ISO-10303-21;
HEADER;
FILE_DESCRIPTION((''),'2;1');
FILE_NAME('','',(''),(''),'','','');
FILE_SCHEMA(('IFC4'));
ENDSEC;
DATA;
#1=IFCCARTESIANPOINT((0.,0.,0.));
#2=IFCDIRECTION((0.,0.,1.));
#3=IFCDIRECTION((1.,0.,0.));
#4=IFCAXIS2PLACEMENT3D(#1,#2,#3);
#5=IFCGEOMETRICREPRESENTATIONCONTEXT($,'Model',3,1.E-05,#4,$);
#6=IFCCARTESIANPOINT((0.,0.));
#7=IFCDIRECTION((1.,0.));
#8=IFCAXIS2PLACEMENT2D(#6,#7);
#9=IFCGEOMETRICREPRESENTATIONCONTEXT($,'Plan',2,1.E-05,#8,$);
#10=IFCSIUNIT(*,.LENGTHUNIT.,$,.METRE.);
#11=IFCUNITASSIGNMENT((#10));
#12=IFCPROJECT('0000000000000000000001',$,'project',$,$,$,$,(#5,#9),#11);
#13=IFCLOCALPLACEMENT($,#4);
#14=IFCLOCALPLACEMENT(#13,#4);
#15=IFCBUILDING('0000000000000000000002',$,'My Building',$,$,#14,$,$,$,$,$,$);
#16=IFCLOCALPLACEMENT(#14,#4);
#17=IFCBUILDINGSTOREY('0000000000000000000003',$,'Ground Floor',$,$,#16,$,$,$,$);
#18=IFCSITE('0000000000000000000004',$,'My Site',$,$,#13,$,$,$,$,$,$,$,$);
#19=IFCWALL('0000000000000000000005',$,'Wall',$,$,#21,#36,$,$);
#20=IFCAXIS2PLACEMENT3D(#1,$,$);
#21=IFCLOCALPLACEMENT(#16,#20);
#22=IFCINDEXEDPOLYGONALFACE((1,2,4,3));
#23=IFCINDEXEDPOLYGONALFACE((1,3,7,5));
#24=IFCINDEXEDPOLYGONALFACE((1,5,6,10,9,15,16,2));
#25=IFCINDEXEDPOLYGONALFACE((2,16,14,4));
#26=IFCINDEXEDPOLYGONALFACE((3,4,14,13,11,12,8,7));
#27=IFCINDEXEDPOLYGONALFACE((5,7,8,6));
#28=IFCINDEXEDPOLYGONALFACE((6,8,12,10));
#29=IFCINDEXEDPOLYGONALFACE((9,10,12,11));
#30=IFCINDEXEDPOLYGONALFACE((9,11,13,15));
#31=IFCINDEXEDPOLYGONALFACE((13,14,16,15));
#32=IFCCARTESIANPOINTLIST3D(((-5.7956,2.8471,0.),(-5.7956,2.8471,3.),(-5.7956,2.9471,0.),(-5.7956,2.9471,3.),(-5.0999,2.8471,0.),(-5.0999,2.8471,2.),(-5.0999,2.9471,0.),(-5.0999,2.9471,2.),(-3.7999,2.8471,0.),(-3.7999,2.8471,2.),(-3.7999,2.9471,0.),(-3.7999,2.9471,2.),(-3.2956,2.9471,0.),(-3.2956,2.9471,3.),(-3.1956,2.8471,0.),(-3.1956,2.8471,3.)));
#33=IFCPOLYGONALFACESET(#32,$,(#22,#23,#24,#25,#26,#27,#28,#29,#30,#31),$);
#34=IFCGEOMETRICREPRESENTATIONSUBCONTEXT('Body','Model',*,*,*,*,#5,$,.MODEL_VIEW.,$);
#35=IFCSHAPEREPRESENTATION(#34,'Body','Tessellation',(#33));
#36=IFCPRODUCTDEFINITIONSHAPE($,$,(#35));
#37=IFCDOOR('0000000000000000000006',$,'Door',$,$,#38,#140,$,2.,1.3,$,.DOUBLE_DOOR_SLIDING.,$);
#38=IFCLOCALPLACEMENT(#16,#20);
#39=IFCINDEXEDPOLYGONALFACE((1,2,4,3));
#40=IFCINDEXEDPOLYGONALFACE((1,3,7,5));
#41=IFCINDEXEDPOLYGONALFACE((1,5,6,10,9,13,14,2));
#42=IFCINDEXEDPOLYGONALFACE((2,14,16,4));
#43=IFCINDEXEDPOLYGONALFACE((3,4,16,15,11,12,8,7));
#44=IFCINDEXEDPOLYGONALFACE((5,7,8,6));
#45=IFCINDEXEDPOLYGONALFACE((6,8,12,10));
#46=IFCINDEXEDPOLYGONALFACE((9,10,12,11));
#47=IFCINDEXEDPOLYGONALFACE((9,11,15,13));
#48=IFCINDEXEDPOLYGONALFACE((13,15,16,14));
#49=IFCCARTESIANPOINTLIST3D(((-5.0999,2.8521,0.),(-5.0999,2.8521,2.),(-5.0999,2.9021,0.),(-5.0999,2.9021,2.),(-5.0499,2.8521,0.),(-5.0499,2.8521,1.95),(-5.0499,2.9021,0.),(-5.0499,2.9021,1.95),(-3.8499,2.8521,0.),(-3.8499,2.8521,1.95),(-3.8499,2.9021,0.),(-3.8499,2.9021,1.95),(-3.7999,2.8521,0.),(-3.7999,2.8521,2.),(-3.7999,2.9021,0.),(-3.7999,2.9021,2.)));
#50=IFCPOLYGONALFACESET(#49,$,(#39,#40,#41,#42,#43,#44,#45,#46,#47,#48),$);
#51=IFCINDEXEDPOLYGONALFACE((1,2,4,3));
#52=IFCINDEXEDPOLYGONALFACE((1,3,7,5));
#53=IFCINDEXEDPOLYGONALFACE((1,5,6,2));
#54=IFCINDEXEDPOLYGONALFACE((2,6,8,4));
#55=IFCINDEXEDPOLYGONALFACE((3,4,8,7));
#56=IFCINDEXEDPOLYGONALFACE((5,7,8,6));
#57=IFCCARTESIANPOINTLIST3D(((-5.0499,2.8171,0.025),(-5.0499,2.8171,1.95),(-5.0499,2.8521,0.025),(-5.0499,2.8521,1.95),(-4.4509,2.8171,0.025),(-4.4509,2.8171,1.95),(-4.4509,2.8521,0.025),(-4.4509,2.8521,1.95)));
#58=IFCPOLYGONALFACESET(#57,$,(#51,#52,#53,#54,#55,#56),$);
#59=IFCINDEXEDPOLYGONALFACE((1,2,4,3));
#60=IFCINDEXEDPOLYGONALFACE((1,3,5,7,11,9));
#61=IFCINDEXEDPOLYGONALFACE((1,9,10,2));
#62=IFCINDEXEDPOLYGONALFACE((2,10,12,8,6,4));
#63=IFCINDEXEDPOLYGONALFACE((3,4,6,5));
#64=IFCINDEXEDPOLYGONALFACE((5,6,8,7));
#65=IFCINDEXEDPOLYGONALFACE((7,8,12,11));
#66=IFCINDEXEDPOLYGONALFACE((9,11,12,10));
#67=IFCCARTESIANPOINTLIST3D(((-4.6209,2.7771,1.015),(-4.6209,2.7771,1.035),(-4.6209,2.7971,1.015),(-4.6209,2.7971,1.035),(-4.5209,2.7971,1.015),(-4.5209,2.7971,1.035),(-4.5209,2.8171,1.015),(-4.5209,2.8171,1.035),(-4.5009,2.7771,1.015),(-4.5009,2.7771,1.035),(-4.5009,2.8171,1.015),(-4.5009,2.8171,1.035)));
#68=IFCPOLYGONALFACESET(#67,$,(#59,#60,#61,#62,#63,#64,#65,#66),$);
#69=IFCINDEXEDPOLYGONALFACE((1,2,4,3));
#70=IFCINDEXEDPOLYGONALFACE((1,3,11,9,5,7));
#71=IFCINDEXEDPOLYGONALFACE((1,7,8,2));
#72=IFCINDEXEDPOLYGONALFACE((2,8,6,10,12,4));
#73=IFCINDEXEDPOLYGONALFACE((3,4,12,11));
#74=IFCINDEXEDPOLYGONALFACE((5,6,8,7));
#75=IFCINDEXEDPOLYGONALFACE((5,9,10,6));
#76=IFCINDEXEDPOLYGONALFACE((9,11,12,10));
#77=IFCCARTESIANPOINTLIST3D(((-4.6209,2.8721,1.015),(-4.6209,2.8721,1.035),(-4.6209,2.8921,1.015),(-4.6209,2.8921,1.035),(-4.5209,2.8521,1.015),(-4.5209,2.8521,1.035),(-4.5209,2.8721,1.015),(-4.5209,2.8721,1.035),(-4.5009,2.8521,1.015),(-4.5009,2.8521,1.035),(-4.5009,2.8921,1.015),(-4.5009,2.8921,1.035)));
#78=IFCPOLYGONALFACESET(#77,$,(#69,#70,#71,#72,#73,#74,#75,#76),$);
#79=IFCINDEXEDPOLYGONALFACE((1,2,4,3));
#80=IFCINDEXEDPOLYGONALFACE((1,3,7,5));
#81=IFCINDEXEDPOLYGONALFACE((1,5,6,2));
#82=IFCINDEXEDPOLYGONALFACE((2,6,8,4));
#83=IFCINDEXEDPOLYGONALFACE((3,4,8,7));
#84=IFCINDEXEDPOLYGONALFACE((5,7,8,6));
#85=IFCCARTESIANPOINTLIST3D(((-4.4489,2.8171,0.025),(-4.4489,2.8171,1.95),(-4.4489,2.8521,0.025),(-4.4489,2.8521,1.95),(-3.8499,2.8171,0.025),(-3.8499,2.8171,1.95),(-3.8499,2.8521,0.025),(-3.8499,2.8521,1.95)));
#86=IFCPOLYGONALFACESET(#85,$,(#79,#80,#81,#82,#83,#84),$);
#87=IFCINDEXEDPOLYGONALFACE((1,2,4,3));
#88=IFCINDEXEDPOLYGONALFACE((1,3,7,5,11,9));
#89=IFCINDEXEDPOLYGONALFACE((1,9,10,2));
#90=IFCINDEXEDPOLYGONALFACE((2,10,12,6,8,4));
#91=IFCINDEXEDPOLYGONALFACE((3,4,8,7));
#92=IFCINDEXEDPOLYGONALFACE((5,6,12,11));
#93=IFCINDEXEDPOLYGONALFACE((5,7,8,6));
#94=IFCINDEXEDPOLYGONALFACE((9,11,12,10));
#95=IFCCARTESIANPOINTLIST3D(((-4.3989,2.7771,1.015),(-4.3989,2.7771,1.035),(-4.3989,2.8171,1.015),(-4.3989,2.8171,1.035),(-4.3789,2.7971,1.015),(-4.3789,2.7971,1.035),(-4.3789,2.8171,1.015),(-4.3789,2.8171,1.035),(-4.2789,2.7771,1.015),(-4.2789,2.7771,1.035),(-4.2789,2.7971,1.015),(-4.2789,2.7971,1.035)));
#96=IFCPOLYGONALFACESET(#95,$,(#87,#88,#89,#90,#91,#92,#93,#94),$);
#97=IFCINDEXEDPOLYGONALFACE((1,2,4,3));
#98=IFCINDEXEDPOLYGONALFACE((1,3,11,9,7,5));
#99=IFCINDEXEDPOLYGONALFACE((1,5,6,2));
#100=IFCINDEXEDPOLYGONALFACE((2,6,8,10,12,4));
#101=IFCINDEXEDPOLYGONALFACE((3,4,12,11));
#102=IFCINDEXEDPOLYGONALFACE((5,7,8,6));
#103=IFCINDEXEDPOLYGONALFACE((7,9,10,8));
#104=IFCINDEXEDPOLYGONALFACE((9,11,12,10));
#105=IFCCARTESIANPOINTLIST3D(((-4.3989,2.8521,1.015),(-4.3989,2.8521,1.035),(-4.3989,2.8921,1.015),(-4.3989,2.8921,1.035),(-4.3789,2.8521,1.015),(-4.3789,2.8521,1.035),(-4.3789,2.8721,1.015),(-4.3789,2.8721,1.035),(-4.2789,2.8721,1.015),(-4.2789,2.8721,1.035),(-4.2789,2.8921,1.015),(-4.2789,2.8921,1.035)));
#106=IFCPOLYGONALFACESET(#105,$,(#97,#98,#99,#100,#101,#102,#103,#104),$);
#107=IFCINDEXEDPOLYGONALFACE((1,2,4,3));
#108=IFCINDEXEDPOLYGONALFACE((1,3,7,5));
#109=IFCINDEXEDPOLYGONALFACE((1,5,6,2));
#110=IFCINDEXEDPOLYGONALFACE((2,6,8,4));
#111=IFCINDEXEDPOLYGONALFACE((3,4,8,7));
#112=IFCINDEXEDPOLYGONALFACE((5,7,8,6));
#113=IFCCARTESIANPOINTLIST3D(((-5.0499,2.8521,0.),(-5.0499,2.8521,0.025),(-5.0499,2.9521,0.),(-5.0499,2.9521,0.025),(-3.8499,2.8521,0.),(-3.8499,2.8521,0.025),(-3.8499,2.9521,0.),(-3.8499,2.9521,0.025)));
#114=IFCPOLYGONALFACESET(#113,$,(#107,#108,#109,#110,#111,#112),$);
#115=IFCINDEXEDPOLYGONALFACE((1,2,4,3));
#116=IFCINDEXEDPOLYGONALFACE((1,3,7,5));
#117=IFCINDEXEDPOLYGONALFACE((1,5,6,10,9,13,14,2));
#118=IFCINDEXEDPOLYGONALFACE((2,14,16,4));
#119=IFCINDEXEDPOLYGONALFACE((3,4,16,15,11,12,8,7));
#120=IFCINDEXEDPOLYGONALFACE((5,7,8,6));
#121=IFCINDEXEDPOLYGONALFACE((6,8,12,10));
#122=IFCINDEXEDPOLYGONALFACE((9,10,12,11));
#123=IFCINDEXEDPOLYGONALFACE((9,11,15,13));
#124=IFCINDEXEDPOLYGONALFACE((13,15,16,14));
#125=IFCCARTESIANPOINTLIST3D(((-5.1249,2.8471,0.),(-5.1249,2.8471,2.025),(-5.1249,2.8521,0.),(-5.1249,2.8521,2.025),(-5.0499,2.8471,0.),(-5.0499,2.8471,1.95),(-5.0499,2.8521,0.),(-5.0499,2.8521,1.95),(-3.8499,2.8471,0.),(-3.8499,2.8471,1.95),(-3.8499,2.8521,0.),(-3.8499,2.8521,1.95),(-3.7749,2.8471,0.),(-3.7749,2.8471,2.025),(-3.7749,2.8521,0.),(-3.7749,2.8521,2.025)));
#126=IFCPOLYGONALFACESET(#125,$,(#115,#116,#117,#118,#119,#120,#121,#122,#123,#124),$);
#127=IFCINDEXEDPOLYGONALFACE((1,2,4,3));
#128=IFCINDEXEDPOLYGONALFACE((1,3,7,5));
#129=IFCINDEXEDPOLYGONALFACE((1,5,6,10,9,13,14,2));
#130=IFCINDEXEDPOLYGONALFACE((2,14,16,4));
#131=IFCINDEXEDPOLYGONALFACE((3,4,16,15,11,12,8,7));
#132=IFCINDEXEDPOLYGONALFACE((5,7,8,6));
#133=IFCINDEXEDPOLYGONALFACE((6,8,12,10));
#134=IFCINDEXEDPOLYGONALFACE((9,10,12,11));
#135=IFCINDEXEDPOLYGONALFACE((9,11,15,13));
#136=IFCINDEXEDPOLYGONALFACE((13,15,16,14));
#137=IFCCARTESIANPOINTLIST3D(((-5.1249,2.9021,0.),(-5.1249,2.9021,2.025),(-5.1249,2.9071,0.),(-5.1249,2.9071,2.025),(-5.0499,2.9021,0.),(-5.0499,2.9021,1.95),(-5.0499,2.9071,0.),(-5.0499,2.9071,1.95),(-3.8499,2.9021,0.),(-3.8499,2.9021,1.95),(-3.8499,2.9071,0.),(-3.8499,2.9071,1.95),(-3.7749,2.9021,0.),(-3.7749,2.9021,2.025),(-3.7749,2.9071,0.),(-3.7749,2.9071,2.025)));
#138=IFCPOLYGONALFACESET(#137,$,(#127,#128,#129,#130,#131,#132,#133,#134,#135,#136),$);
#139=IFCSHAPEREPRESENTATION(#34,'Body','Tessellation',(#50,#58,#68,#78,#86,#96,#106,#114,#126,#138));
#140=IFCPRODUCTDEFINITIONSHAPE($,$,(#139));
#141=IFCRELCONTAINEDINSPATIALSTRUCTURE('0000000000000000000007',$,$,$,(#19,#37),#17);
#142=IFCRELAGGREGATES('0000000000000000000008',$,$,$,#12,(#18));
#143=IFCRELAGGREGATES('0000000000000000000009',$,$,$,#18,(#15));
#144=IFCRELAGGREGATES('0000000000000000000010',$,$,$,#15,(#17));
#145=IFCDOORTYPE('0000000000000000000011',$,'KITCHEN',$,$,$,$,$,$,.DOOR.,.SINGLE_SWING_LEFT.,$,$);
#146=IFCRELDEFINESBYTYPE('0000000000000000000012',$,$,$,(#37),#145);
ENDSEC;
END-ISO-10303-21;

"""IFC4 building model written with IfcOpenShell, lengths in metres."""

from ifc_helpers import new_model, entity, si_unit, frame, origin_with_axes, origin_2d_with_axis, place, context, subcontext, project, spatial, line, indexed_curve, outline, extrude, shape, source, transform, mapped, type_object, type_shapes, element, fill, save


model = new_model("IFC4")

# Units and contexts
model_context = context("Model", 3, precision=1e-05, world=origin_with_axes())
plan_context = context("Plan", 2, precision=1e-05, world=origin_2d_with_axis())
body_context_1 = subcontext(model_context, "Body", "Model", "MODEL_VIEW")
body_context_2 = subcontext(plan_context, "Body", "Plan", "PLAN_VIEW")
ifc_project = project(units=[si_unit("LENGTHUNIT", "METRE")], contexts=[model_context, plan_context])

# Site, building, storey
site_placement = place(None, origin_with_axes())
site = spatial("IfcSite", under=ifc_project, at=site_placement, Name="My Site")
building_placement = place(site_placement, origin_with_axes())
building = spatial("IfcBuilding", under=site, at=building_placement, Name="My Building")
storey_placement = place(building_placement, origin_with_axes())
storey = spatial("IfcBuildingStorey", under=building, at=storey_placement, Name="Ground Floor")

# Wall, opening, door
wall_1_placement = place(storey_placement, frame((-3.2956, 2.9471, 0.0), z_axis=(0.0, 0.0, 1.0), x_axis=(-1.0, 0.0, 0.0)))
wall_1 = element("IfcWall", 1, at=wall_1_placement, inside=storey, Name="Wall", context=body_context_1, shape_type="SweptSolid", body=[
    extrude(outline(indexed_curve([(0.0, 0.0), (-0.1, 0.1), (2.5, 0.1), (2.5, 0.0)], segments=[line(1, 2, 3, 4, 1)])), origin_with_axes(), (0.0, 0.0, 1.0), 3.0),
])
shared_shape_1 = source(origin_with_axes(), body_context_1, "Body", "SweptSolid", [
    extrude(outline(indexed_curve([(0.0, 0.0), (1.3, 0.0), (1.3, 2.0), (0.0, 2.0)], segments=[line(1, 2, 3, 4, 1)])), frame((0.0, -0.6, 0.0), z_axis=(0.0, -1.0, 0.0), x_axis=(1.0, 0.0, 0.0)), (0.0, 0.0, -1.0), 1.2),
])
opening_1_placement = place(wall_1_placement, frame((1.8043, 0.095, 0.0), z_axis=(0.0, 0.0, 1.0), x_axis=(-1.0, 0.0, 0.0)))
opening_1 = element("IfcOpeningElement", 2, at=opening_1_placement, cuts=wall_1, PredefinedType="OPENING", context=body_context_1, shape_type="MappedRepresentation", body=[
    mapped(shared_shape_1, transform((0.0, 0.0, 0.0), x_axis=(1.0, 0.0, 0.0), y_axis=(0.0, 1.0, 0.0), z_axis=(0.0, 0.0, 1.0), scale=1.0)),
])
door_type = type_object("IfcDoorType", Name="KITCHEN", OperationType="SINGLE_SWING_LEFT", PredefinedType="DOOR")
shared_shape_2 = source(origin_with_axes(), body_context_1, "Body", "SweptSolid", [
    extrude(outline(indexed_curve([(0.0, 0.0), (0.0, 2.0), (1.3, 2.0), (1.3, 0.0), (1.25, 0.0), (1.25, 1.95), (0.05, 1.95), (0.05, 0.0)], segments=[line(1, 2, 3, 4, 5, 6, 7, 8, 1)])), frame((0.0, 0.0, 0.0), z_axis=(0.0, -1.0, 0.0), x_axis=(1.0, 0.0, 0.0)), (0.0, 0.0, -1.0), 0.05),
    extrude(outline(indexed_curve([(0.0, 0.0), (0.599, 0.0), (0.599, 0.035), (0.0, 0.035)], segments=[line(1, 2, 3, 4, 1)])), frame((0.05, -0.035, 0.025), z_axis=(0.0, 0.0, 1.0), x_axis=(1.0, 0.0, 0.0)), (0.0, 0.0, 1.0), 1.925),
    extrude(outline(indexed_curve([(0.0, 0.0), (0.0, -0.04), (-0.12, -0.04), (-0.12, -0.02), (-0.02, -0.02), (-0.02, 0.0)], segments=[line(1, 2, 3, 4, 5, 6, 1)])), frame((0.599, -0.035, 1.015), z_axis=(0.0, 0.0, 1.0), x_axis=(1.0, 0.0, 0.0)), (0.0, 0.0, 1.0), 0.02),
    extrude(outline(indexed_curve([(0.0, 0.0), (0.0, 0.04), (-0.12, 0.04), (-0.12, 0.02), (-0.02, 0.02), (-0.02, 0.0)], segments=[line(1, 2, 3, 4, 5, 6, 1)])), frame((0.599, 0.0, 1.015), z_axis=(0.0, 0.0, 1.0), x_axis=(1.0, 0.0, 0.0)), (0.0, 0.0, 1.0), 0.02),
    extrude(outline(indexed_curve([(0.0, 0.0), (-0.599, 0.0), (-0.599, 0.035), (0.0, 0.035)], segments=[line(1, 2, 3, 4, 1)])), frame((1.25, -0.035, 0.025), z_axis=(0.0, 0.0, 1.0), x_axis=(1.0, 0.0, 0.0)), (0.0, 0.0, 1.0), 1.925),
    extrude(outline(indexed_curve([(0.0, 0.0), (0.0, -0.04), (0.12, -0.04), (0.12, -0.02), (0.02, -0.02), (0.02, 0.0)], segments=[line(1, 2, 3, 4, 5, 6, 1)])), frame((0.701, -0.035, 1.015), z_axis=(0.0, 0.0, 1.0), x_axis=(1.0, 0.0, 0.0)), (0.0, 0.0, 1.0), 0.02),
    extrude(outline(indexed_curve([(0.0, 0.0), (0.0, 0.04), (0.12, 0.04), (0.12, 0.02), (0.02, 0.02), (0.02, 0.0)], segments=[line(1, 2, 3, 4, 5, 6, 1)])), frame((0.701, 0.0, 1.015), z_axis=(0.0, 0.0, 1.0), x_axis=(1.0, 0.0, 0.0)), (0.0, 0.0, 1.0), 0.02),
    extrude(outline(indexed_curve([(0.0, 0.0), (1.2, 0.0), (1.2, 0.1), (0.0, 0.1)], segments=[line(1, 2, 3, 4, 1)])), frame((0.05, 0.0, 0.0), z_axis=(0.0, 0.0, 1.0), x_axis=(1.0, 0.0, 0.0)), (0.0, 0.0, 1.0), 0.025),
    extrude(outline(indexed_curve([(0.0, 0.0), (0.0, 2.025), (1.35, 2.025), (1.35, 0.0), (1.275, 0.0), (1.275, 1.95), (0.075, 1.95), (0.075, 0.0)], segments=[line(1, 2, 3, 4, 5, 6, 7, 8, 1)])), frame((-0.025, -0.005, 0.0), z_axis=(0.0, -1.0, 0.0), x_axis=(1.0, 0.0, 0.0)), (0.0, 0.0, -1.0), 0.005),
    extrude(outline(indexed_curve([(0.0, 0.0), (0.0, 2.025), (1.35, 2.025), (1.35, 0.0), (1.275, 0.0), (1.275, 1.95), (0.075, 1.95), (0.075, 0.0)], segments=[line(1, 2, 3, 4, 5, 6, 7, 8, 1)])), frame((-0.025, 0.05, 0.0), z_axis=(0.0, -1.0, 0.0), x_axis=(1.0, 0.0, 0.0)), (0.0, 0.0, -1.0), 0.005),
])
shared_shape_3 = source(origin_with_axes(), body_context_2, "Body", "Curve2D", [
    entity("IfcIndexedPolyCurve", entity("IfcCartesianPointList2D", [[0.0, 0.0], [0.05, 0.0], [0.05, 0.05], [0.0, 0.05]]), [entity("IfcLineIndex", [1, 2, 3, 4, 1])]),
    entity("IfcIndexedPolyCurve", entity("IfcCartesianPointList2D", [[1.3, 0.0], [1.25, 0.0], [1.25, 0.05], [1.3, 0.05]]), [entity("IfcLineIndex", [1, 2, 3, 4, 1])]),
    entity("IfcIndexedPolyCurve", entity("IfcCartesianPointList2D", [[-0.25, -0.035], [0.35, -0.035], [0.35, 0.0], [-0.25, 0.0]]), [entity("IfcLineIndex", [1, 2, 3, 4, 1])]),
    entity("IfcIndexedPolyCurve", entity("IfcCartesianPointList2D", [[1.55, -0.035], [0.95, -0.035], [0.95, 0.0], [1.55, 0.0]]), [entity("IfcLineIndex", [1, 2, 3, 4, 1])]),
])
type_shapes(door_type, [shared_shape_2, shared_shape_3])
door_placement = place(opening_1_placement, frame((0.0, 0.0, 0.0), z_axis=(0.0, 0.0, 1.0), x_axis=(1.0, 0.0, 0.0)))
door = element("IfcDoor", 3, at=door_placement, inside=storey, type_object=door_type, Name="Door", OperationType="DOUBLE_DOOR_SLIDING", OverallHeight=2.0, OverallWidth=1.3, shapes=[
    shape(body_context_1, "Body", "MappedRepresentation", [mapped(shared_shape_2, transform((0.0, 0.0, 0.0), x_axis=(1.0, 0.0, 0.0), y_axis=(0.0, 1.0, 0.0), z_axis=(0.0, 0.0, 1.0), scale=1.0))]),
    shape(body_context_2, "Body", "MappedRepresentation", [mapped(shared_shape_3, transform((0.0, 0.0, 0.0), x_axis=(1.0, 0.0, 0.0), y_axis=(0.0, 1.0, 0.0), z_axis=(0.0, 0.0, 1.0), scale=1.0))]),
])
fill(opening_1, door)

save(model, "model.ifc")
